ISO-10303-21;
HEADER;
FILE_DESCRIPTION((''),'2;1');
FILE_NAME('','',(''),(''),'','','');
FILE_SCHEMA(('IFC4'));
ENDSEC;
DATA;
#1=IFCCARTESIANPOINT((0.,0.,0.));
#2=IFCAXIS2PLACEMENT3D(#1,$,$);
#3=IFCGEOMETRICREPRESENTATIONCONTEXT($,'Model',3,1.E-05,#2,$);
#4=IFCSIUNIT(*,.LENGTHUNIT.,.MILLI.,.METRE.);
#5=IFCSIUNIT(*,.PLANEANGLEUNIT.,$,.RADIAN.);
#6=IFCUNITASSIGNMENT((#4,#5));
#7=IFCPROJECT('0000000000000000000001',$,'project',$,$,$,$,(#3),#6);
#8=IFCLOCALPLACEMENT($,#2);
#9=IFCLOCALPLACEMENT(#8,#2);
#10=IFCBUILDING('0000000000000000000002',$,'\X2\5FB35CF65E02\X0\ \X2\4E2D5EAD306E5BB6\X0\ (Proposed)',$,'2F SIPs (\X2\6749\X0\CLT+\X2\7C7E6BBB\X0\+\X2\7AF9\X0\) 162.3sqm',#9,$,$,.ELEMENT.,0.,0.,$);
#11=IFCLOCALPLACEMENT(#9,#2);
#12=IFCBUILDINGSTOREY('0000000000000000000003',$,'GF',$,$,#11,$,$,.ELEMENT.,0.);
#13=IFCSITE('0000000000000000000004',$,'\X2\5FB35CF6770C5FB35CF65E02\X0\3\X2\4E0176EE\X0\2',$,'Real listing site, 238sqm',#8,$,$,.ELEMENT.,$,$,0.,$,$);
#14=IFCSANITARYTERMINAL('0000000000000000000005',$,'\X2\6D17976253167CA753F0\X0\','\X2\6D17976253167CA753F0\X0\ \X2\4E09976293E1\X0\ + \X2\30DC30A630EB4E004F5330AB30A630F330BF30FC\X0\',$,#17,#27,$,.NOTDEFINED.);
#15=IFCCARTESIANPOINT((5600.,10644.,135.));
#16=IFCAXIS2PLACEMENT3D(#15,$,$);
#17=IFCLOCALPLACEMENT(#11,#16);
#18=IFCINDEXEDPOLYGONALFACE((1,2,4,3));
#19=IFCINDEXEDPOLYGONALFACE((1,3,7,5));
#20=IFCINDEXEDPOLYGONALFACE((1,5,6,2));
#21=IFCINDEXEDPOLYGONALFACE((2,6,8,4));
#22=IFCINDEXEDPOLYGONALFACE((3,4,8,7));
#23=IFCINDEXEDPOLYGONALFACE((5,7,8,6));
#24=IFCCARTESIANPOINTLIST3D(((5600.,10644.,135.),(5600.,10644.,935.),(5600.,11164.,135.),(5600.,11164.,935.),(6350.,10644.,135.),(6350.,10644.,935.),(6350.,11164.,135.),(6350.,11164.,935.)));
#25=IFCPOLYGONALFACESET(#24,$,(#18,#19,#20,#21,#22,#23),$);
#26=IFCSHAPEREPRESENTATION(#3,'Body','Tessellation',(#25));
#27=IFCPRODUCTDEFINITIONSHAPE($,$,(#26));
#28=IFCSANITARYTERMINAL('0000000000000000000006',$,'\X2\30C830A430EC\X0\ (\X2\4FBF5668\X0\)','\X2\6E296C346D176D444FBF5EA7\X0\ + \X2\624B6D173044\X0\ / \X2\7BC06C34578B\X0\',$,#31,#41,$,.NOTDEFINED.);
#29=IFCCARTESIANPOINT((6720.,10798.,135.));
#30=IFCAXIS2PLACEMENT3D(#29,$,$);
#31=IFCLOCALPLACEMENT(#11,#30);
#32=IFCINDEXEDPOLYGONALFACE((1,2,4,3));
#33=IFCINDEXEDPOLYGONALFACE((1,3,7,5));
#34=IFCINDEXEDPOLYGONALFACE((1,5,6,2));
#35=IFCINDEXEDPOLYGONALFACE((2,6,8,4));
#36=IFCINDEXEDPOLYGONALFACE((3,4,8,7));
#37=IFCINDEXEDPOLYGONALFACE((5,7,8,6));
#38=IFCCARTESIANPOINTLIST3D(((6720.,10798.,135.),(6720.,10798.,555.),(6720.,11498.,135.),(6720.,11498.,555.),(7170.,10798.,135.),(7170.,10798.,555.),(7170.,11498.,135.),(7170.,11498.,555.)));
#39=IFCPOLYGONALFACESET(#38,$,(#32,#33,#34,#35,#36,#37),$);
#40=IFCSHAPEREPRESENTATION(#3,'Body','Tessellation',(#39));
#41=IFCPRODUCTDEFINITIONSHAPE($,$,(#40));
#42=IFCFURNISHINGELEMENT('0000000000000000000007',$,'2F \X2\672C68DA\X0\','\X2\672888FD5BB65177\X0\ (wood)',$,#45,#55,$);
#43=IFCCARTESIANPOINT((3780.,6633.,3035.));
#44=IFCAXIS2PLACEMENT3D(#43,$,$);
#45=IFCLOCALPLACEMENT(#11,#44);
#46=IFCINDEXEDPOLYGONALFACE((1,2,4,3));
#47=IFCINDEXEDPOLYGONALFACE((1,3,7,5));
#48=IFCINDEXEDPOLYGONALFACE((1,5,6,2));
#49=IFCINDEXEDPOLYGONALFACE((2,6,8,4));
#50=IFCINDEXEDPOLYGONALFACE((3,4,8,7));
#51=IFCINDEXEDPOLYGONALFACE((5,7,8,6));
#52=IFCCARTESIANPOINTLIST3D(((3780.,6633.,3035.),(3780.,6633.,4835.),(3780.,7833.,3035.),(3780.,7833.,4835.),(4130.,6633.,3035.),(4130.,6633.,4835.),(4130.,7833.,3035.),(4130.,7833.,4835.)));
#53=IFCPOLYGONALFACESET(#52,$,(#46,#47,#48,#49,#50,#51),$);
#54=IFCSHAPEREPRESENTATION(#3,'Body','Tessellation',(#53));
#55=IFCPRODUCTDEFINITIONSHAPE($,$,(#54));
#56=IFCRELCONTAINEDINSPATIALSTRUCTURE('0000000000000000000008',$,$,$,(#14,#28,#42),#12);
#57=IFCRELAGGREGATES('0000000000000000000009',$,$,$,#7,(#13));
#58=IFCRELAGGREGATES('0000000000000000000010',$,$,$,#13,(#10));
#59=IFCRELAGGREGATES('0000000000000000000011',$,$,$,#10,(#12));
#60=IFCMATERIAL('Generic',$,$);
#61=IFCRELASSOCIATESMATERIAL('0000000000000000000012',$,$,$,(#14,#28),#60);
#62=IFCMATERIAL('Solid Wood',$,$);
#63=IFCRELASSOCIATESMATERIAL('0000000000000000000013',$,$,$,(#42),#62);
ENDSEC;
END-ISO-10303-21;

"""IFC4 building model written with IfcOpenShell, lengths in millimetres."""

from ifc_helpers import new_model, si_unit, frame, frame_2d, origin, place, context, project, spatial, rectangle, extrude, material, element, save


model = new_model("IFC4")

# Units and contexts
model_context = context("Model", 3, precision=1e-05, world=origin())
ifc_project = project(units=[si_unit("LENGTHUNIT", "METRE", prefix="MILLI"), si_unit("PLANEANGLEUNIT", "RADIAN")], contexts=[model_context])

# Site, building, storey
site_placement = place(None, origin())
site = spatial("IfcSite", under=ifc_project, at=site_placement, Name="徳島県徳島市3丁目2", ObjectType="Real listing site, 238sqm", CompositionType="ELEMENT", RefElevation=0.0)
building_placement = place(site_placement, origin())
building = spatial("IfcBuilding", under=site, at=building_placement, Name="徳島市 中庭の家 (Proposed)", ObjectType="2F SIPs (杉CLT+籾殻+竹) 162.3sqm", CompositionType="ELEMENT", ElevationOfRefHeight=0.0, ElevationOfTerrain=0.0)
storey_placement = place(building_placement, origin())
storey = spatial("IfcBuildingStorey", under=building, at=storey_placement, Name="GF", CompositionType="ELEMENT", Elevation=0.0)

# Shared definitions
ifc_material_1 = material(Name="Solid Wood")
ifc_material_2 = material(Name="Generic")

# Sanitary terminals
sanitary_terminal_1_placement = place(storey_placement, frame((5600.0, 10644.0, 135.0)))
element("IfcSanitaryTerminal", 1, at=sanitary_terminal_1_placement, inside=storey, material=ifc_material_2, Name="洗面化粧台", Description="洗面化粧台 三面鏡 + ボウル一体カウンター", PredefinedType="NOTDEFINED", context=model_context, shape_type="SweptSolid", body=[
    extrude(rectangle(XDim=750.0, YDim=520.0, at=frame_2d((375.0, 260.0))), frame((5600.0, 10644.0, 135.0)), (0.0, 0.0, 1.0), 800.0),
])
sanitary_terminal_2_placement = place(storey_placement, frame((6720.0, 10798.0, 135.0)))
element("IfcSanitaryTerminal", 2, at=sanitary_terminal_2_placement, inside=storey, material=ifc_material_2, Name="トイレ (便器)", Description="温水洗浄便座 + 手洗い / 節水型", PredefinedType="NOTDEFINED", context=model_context, shape_type="SweptSolid", body=[
    extrude(rectangle(XDim=450.0, YDim=700.0, at=frame_2d((225.0, 350.0))), frame((6720.0, 10798.0, 135.0)), (0.0, 0.0, 1.0), 420.0),
])

# Furnishing element
furnishing_placement = place(storey_placement, frame((3780.0, 6633.0, 3035.0)))
element("IfcFurnishingElement", 3, at=furnishing_placement, inside=storey, material=ifc_material_1, Name="2F 本棚", Description="木製家具 (wood)", context=model_context, shape_type="SweptSolid", body=[
    extrude(rectangle(XDim=350.0, YDim=1200.0, at=frame_2d((175.0, 600.0))), frame((3780.0, 6633.0, 3035.0)), (0.0, 0.0, 1.0), 1800.0),
])

save(model, "model.ifc")
